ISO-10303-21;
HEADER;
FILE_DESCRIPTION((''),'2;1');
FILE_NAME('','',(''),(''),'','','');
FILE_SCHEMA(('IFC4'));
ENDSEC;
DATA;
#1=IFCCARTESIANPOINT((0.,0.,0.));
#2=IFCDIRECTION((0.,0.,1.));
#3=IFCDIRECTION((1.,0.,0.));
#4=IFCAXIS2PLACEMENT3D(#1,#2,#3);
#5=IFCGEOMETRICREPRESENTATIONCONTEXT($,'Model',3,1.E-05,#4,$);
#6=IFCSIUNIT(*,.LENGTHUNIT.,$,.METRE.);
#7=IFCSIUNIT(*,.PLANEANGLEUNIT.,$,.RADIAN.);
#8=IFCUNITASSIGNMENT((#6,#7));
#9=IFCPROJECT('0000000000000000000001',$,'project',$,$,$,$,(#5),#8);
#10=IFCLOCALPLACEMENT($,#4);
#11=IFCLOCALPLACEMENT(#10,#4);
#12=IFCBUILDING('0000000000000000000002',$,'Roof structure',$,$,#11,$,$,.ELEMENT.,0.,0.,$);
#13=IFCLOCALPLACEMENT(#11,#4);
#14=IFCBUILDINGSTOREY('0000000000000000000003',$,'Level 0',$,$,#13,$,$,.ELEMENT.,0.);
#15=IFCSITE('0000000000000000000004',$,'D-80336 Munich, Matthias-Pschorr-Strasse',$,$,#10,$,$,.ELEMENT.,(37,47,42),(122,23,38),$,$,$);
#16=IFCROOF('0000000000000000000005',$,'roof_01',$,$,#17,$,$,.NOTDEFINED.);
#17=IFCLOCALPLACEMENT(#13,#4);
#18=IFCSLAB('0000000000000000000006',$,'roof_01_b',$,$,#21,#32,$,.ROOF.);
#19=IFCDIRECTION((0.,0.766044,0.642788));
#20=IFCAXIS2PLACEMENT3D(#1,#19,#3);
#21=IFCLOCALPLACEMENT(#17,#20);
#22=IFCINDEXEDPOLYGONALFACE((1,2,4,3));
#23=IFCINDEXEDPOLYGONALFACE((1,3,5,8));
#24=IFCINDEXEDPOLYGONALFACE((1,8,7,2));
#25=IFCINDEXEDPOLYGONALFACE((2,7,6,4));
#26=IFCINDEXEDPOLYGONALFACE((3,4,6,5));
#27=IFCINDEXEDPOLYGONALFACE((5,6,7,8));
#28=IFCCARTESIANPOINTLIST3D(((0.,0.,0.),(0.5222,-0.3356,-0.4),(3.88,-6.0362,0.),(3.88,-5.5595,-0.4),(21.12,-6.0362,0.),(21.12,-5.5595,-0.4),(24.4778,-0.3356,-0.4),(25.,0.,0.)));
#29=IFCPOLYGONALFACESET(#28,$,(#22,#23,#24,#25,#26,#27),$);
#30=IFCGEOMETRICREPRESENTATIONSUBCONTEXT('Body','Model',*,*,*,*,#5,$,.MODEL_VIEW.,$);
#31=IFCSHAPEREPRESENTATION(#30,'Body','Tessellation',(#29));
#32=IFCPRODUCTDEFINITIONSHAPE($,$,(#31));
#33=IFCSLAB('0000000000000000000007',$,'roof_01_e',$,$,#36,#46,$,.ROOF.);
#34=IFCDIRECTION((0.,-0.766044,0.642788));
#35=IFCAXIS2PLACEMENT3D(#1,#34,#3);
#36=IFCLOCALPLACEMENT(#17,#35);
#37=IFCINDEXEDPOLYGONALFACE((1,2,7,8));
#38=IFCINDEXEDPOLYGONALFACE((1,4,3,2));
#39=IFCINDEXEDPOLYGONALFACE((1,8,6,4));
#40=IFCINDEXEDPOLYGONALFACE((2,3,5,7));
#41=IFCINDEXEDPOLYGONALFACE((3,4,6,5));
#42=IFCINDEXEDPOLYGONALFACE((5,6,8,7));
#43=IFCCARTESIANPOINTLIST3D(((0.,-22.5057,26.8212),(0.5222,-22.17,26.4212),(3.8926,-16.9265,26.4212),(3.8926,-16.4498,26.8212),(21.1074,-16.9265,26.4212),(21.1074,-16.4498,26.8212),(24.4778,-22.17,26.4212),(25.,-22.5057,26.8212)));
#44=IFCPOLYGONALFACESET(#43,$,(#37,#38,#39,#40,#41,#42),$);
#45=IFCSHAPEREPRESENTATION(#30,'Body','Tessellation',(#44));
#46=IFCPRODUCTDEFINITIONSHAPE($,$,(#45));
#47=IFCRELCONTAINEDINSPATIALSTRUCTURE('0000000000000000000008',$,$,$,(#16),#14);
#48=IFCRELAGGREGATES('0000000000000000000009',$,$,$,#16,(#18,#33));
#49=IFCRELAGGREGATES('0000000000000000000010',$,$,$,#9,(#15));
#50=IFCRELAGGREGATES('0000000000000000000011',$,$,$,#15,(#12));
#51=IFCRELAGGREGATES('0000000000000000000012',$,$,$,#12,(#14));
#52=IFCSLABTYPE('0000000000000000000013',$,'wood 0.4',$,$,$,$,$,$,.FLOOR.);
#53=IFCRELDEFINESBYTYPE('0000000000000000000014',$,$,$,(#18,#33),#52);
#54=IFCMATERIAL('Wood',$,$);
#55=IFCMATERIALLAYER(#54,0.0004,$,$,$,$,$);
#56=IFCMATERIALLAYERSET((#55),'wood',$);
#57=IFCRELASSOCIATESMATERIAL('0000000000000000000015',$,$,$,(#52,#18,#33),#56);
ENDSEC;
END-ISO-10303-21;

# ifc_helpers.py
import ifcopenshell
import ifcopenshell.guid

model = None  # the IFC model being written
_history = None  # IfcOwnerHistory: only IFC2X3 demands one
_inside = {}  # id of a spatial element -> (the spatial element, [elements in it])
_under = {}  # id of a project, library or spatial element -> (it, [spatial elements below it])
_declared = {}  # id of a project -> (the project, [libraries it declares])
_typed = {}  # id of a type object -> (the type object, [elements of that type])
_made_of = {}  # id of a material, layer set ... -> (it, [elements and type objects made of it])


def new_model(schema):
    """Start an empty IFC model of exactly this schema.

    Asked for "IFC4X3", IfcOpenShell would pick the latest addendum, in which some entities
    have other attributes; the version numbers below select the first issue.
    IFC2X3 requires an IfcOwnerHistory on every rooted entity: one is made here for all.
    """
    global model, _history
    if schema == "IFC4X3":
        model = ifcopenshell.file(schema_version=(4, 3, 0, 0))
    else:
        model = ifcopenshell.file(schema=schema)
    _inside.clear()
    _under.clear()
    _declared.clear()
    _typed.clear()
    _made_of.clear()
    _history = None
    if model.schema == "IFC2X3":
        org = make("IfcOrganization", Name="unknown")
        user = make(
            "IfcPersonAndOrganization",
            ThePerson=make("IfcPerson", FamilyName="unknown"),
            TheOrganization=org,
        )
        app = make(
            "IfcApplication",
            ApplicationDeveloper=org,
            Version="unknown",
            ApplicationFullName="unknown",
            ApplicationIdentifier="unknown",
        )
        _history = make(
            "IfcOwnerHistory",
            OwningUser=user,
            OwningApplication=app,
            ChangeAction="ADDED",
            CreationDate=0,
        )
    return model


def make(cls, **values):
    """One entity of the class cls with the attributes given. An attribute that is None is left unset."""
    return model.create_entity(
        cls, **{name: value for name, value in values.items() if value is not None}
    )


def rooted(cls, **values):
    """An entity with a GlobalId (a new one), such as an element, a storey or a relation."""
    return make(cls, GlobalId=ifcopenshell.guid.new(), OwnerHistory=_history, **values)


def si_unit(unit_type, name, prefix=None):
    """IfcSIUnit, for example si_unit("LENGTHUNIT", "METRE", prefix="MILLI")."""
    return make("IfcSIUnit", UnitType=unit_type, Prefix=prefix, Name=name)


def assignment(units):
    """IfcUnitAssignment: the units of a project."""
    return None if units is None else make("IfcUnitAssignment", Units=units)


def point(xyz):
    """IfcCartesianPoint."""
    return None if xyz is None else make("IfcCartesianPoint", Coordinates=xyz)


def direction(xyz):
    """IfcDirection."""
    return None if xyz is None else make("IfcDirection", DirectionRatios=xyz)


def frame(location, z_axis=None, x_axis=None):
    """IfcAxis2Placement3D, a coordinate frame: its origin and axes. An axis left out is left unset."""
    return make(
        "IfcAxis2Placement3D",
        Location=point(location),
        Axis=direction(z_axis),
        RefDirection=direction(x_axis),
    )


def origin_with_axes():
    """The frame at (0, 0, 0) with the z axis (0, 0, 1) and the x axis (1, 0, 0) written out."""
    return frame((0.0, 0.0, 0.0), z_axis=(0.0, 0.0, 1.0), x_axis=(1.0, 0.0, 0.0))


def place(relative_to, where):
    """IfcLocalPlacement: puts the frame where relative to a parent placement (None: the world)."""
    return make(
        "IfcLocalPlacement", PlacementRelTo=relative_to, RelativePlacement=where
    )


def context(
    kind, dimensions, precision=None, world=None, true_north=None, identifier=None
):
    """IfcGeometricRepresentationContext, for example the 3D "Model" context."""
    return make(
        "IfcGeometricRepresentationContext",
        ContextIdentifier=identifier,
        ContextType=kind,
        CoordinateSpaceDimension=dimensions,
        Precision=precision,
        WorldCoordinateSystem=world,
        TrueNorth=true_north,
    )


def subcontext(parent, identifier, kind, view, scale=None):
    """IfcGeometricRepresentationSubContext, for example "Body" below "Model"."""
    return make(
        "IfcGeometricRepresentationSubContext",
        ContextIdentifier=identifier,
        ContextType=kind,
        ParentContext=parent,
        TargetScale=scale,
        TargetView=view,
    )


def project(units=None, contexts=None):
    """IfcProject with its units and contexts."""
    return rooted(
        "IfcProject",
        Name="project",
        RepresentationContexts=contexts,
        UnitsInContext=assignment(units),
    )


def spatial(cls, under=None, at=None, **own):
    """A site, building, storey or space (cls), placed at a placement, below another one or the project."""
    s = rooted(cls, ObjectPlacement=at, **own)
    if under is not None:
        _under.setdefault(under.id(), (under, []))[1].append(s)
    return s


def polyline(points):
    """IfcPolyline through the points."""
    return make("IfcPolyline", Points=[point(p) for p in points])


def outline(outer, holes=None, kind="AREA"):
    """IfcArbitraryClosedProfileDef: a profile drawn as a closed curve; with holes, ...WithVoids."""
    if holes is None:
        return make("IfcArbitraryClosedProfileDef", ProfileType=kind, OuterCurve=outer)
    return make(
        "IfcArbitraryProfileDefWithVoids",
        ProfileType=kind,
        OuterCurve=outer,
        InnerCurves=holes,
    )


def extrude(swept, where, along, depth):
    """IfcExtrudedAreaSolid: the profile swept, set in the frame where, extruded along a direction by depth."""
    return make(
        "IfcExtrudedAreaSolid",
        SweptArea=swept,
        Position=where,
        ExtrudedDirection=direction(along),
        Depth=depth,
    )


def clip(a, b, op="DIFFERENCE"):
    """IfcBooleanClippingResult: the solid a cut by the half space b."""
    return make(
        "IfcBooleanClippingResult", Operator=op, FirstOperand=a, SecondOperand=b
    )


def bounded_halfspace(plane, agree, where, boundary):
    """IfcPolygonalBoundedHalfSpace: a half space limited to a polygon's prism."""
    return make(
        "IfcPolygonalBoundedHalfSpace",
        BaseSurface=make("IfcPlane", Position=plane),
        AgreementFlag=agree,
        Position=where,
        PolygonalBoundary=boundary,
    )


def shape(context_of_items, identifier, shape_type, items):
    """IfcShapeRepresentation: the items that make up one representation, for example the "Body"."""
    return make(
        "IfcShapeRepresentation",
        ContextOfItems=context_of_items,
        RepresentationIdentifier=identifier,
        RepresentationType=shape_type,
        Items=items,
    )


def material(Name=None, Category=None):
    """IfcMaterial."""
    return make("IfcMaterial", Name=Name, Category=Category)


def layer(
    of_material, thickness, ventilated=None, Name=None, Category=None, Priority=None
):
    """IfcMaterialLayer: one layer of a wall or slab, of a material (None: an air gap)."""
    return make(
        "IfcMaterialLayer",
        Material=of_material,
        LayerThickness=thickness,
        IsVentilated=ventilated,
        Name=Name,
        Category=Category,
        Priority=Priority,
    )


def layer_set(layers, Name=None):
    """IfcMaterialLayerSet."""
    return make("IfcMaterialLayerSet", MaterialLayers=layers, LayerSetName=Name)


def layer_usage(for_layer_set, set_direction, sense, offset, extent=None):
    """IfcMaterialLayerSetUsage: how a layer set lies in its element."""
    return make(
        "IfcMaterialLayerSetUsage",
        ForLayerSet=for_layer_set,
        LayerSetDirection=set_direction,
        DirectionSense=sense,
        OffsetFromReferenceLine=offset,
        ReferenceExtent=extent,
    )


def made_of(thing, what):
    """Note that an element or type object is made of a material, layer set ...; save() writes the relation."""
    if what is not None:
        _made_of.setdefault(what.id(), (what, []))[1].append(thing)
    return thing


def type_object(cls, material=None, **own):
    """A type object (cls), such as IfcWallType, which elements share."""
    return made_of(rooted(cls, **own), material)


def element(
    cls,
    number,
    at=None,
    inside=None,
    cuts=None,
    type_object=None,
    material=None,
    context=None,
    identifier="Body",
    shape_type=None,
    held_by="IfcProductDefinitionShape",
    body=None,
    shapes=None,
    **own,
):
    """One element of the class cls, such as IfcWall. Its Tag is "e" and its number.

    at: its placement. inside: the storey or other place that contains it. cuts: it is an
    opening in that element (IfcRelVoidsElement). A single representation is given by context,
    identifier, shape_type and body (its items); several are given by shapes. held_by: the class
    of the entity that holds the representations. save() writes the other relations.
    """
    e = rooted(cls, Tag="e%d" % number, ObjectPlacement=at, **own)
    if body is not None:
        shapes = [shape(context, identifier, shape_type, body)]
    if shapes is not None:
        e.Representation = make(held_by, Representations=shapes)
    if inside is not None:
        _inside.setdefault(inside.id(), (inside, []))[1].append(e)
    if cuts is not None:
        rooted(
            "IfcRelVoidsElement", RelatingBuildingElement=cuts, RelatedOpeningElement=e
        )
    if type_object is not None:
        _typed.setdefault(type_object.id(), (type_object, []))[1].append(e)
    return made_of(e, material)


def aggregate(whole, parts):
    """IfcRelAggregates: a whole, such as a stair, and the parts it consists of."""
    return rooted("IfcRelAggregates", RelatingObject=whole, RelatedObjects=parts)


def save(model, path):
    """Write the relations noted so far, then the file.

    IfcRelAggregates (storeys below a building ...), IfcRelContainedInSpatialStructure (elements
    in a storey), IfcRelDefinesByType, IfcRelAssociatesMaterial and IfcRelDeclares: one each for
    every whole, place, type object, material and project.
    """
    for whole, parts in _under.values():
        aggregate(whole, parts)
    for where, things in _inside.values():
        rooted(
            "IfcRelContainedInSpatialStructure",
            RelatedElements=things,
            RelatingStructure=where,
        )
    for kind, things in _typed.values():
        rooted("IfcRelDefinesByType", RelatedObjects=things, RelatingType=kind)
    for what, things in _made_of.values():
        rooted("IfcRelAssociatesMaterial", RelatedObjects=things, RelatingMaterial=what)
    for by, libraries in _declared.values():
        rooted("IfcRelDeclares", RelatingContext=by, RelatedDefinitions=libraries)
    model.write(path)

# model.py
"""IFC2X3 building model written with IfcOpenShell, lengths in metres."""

from ifc_helpers import new_model, si_unit, frame, origin_with_axes, place, context, subcontext, project, spatial, polyline, outline, extrude, clip, bounded_halfspace, material, layer, layer_set, layer_usage, type_object, element, aggregate, save


model = new_model("IFC2X3")

# Units and contexts
model_context = context("Model", 3, precision=1e-05, world=origin_with_axes())
body_context = subcontext(model_context, "Body", "Model", "MODEL_VIEW")
ifc_project = project(units=[si_unit("LENGTHUNIT", "METRE"), si_unit("PLANEANGLEUNIT", "RADIAN")], contexts=[model_context])

# Site, building, storey
site_placement = place(None, origin_with_axes())
site = spatial("IfcSite", under=ifc_project, at=site_placement, Name="D-80336 Munich, Matthias-Pschorr-Strasse", CompositionType="ELEMENT", RefLatitude=(37, 47, 42), RefLongitude=(122, 23, 38))
building_placement = place(site_placement, origin_with_axes())
building = spatial("IfcBuilding", under=site, at=building_placement, Name="Roof structure", CompositionType="ELEMENT", ElevationOfRefHeight=0.0, ElevationOfTerrain=0.0)
storey_placement = place(building_placement, origin_with_axes())
storey = spatial("IfcBuildingStorey", under=building, at=storey_placement, Name="Level 0", CompositionType="ELEMENT", Elevation=0.0)

# Roof, slabs
roof_placement = place(storey_placement, origin_with_axes())
roof = element("IfcRoof", 1, at=roof_placement, inside=storey, Name="roof_01", ShapeType="NOTDEFINED")
ifc_material_1 = material(Name="Wood")
ifc_layer_1 = layer(ifc_material_1, 0.0004)
ifc_layer_set_1 = layer_set([ifc_layer_1], Name="wood")
slab_type = type_object("IfcSlabType", Name="wood 0.4", PredefinedType="FLOOR", material=ifc_layer_set_1)
ifc_layer_usage_1 = layer_usage(ifc_layer_set_1, "AXIS3", "POSITIVE", 0.0)
slab_1_placement = place(roof_placement, frame((0.0, 0.0, 0.0), z_axis=(0.0, 0.766044, 0.642788), x_axis=(1.0, 0.0, 0.0)))
slab_1 = element("IfcSlab", 2, at=slab_1_placement, type_object=slab_type, material=ifc_layer_usage_1, Name="roof_01_b", PredefinedType="ROOF", context=body_context, shape_type="Clipping", body=[
    clip(clip(clip(clip(extrude(outline(polyline([(8.62, -3.0181), (-8.62, -3.0181), (-12.5, 3.0181), (12.5, 3.0181), (8.62, -3.0181)])), frame((12.5, -3.0181, -0.4), z_axis=(0.0, 0.0, 1.0), x_axis=(1.0, 0.0, 0.0)), (0.0, 0.0, 1.0), 0.4), bounded_halfspace(frame((12.5, -8.0348, -9.5756), z_axis=(0.707107, -0.454519, -0.541675), x_axis=(0.707107, 0.454519, 0.541675)), False, frame((12.5, -3.0181, -0.4), z_axis=(0.0, 0.0, 1.0), x_axis=(1.0, 0.0, 0.0)), polyline([(8.62, -2.5414), (11.9778, 2.6825), (12.5, 3.0181), (8.62, -3.0181), (8.62, -2.5414)]))), bounded_halfspace(frame((0.0, 0.0, 0.0), z_axis=(0.0, 0.766044, -0.642788), x_axis=(-1.0, 0.0, 0.0)), False, frame((12.5, -3.0181, -0.4), z_axis=(0.0, 0.0, 1.0), x_axis=(1.0, 0.0, 0.0)), polyline([(12.5, 3.0181), (11.9778, 2.6825), (-11.9778, 2.6825), (-12.5, 3.0181), (12.5, 3.0181)]))), bounded_halfspace(frame((0.0, 0.0, 0.0), z_axis=(-0.707107, -0.454519, -0.541675), x_axis=(0.707107, -0.454519, -0.541675)), False, frame((12.5, -3.0181, -0.4), z_axis=(0.0, 0.0, 1.0), x_axis=(1.0, 0.0, 0.0)), polyline([(-8.62, -3.0181), (-12.5, 3.0181), (-11.9778, 2.6825), (-8.62, -2.5414), (-8.62, -3.0181)]))), bounded_halfspace(frame((0.0, -2.494, -2.9723), z_axis=(0.0, -0.642788, -0.766044), x_axis=(1.0, 0.0, 0.0)), False, frame((12.5, -3.0181, -0.4), z_axis=(0.0, 0.0, 1.0), x_axis=(1.0, 0.0, 0.0)), polyline([(-8.62, -3.0181), (-8.62, -2.5414), (8.62, -2.5414), (8.62, -3.0181), (-8.62, -3.0181)]))),
])
ifc_layer_usage_2 = layer_usage(ifc_layer_set_1, "AXIS3", "POSITIVE", 0.0)
slab_2_placement = place(roof_placement, frame((0.0, 0.0, 0.0), z_axis=(0.0, -0.766044, 0.642788), x_axis=(1.0, 0.0, 0.0)))
slab_2 = element("IfcSlab", 3, at=slab_2_placement, type_object=slab_type, material=ifc_layer_usage_2, Name="roof_01_e", PredefinedType="ROOF", context=body_context, shape_type="Clipping", body=[
    clip(clip(clip(clip(extrude(outline(polyline([(-12.5, -3.0279), (-8.6074, 3.0279), (8.6074, 3.0279), (12.5, -3.0279), (-12.5, -3.0279)])), frame((12.5, -19.4778, 26.4212), z_axis=(0.0, 0.0, 1.0), x_axis=(1.0, 0.0, 0.0)), (0.0, 0.0, 1.0), 0.4), bounded_halfspace(frame((-5.0063, -3.218, 3.8351), z_axis=(0.707107, 0.454519, -0.541675), x_axis=(-0.707107, 0.454519, -0.541675)), False, frame((12.5, -19.4778, 26.4212), z_axis=(0.0, 0.0, 1.0), x_axis=(1.0, 0.0, 0.0)), polyline([(8.6074, 3.0279), (12.5, -3.0279), (11.9778, -2.6923), (8.6074, 2.5512), (8.6074, 3.0279)]))), bounded_halfspace(frame((17.5063, -11.2528, 13.4106), z_axis=(-0.707107, 0.454519, -0.541675), x_axis=(-0.707107, -0.454519, 0.541675)), False, frame((12.5, -19.4778, 26.4212), z_axis=(0.0, 0.0, 1.0), x_axis=(1.0, 0.0, 0.0)), polyline([(-8.6074, 2.5512), (-11.9778, -2.6923), (-12.5, -3.0279), (-8.6074, 3.0279), (-8.6074, 2.5512)]))), bounded_halfspace(frame((0.0, 0.0, 0.0), z_axis=(0.0, -0.766044, -0.642788), x_axis=(-1.0, 0.0, 0.0)), False, frame((12.5, -19.4778, 26.4212), z_axis=(0.0, 0.0, 1.0), x_axis=(1.0, 0.0, 0.0)), polyline([(-12.5, -3.0279), (-11.9778, -2.6923), (11.9778, -2.6923), (12.5, -3.0279), (-12.5, -3.0279)]))), bounded_halfspace(frame((0.0, -20.0036, 23.8393), z_axis=(0.0, 0.642788, -0.766044), x_axis=(-1.0, 0.0, 0.0)), False, frame((12.5, -19.4778, 26.4212), z_axis=(0.0, 0.0, 1.0), x_axis=(1.0, 0.0, 0.0)), polyline([(-8.6074, 2.5512), (-8.6074, 3.0279), (8.6074, 3.0279), (8.6074, 2.5512), (-8.6074, 2.5512)]))),
])
aggregate(roof, [slab_1, slab_2])

save(model, "model.ifc")
